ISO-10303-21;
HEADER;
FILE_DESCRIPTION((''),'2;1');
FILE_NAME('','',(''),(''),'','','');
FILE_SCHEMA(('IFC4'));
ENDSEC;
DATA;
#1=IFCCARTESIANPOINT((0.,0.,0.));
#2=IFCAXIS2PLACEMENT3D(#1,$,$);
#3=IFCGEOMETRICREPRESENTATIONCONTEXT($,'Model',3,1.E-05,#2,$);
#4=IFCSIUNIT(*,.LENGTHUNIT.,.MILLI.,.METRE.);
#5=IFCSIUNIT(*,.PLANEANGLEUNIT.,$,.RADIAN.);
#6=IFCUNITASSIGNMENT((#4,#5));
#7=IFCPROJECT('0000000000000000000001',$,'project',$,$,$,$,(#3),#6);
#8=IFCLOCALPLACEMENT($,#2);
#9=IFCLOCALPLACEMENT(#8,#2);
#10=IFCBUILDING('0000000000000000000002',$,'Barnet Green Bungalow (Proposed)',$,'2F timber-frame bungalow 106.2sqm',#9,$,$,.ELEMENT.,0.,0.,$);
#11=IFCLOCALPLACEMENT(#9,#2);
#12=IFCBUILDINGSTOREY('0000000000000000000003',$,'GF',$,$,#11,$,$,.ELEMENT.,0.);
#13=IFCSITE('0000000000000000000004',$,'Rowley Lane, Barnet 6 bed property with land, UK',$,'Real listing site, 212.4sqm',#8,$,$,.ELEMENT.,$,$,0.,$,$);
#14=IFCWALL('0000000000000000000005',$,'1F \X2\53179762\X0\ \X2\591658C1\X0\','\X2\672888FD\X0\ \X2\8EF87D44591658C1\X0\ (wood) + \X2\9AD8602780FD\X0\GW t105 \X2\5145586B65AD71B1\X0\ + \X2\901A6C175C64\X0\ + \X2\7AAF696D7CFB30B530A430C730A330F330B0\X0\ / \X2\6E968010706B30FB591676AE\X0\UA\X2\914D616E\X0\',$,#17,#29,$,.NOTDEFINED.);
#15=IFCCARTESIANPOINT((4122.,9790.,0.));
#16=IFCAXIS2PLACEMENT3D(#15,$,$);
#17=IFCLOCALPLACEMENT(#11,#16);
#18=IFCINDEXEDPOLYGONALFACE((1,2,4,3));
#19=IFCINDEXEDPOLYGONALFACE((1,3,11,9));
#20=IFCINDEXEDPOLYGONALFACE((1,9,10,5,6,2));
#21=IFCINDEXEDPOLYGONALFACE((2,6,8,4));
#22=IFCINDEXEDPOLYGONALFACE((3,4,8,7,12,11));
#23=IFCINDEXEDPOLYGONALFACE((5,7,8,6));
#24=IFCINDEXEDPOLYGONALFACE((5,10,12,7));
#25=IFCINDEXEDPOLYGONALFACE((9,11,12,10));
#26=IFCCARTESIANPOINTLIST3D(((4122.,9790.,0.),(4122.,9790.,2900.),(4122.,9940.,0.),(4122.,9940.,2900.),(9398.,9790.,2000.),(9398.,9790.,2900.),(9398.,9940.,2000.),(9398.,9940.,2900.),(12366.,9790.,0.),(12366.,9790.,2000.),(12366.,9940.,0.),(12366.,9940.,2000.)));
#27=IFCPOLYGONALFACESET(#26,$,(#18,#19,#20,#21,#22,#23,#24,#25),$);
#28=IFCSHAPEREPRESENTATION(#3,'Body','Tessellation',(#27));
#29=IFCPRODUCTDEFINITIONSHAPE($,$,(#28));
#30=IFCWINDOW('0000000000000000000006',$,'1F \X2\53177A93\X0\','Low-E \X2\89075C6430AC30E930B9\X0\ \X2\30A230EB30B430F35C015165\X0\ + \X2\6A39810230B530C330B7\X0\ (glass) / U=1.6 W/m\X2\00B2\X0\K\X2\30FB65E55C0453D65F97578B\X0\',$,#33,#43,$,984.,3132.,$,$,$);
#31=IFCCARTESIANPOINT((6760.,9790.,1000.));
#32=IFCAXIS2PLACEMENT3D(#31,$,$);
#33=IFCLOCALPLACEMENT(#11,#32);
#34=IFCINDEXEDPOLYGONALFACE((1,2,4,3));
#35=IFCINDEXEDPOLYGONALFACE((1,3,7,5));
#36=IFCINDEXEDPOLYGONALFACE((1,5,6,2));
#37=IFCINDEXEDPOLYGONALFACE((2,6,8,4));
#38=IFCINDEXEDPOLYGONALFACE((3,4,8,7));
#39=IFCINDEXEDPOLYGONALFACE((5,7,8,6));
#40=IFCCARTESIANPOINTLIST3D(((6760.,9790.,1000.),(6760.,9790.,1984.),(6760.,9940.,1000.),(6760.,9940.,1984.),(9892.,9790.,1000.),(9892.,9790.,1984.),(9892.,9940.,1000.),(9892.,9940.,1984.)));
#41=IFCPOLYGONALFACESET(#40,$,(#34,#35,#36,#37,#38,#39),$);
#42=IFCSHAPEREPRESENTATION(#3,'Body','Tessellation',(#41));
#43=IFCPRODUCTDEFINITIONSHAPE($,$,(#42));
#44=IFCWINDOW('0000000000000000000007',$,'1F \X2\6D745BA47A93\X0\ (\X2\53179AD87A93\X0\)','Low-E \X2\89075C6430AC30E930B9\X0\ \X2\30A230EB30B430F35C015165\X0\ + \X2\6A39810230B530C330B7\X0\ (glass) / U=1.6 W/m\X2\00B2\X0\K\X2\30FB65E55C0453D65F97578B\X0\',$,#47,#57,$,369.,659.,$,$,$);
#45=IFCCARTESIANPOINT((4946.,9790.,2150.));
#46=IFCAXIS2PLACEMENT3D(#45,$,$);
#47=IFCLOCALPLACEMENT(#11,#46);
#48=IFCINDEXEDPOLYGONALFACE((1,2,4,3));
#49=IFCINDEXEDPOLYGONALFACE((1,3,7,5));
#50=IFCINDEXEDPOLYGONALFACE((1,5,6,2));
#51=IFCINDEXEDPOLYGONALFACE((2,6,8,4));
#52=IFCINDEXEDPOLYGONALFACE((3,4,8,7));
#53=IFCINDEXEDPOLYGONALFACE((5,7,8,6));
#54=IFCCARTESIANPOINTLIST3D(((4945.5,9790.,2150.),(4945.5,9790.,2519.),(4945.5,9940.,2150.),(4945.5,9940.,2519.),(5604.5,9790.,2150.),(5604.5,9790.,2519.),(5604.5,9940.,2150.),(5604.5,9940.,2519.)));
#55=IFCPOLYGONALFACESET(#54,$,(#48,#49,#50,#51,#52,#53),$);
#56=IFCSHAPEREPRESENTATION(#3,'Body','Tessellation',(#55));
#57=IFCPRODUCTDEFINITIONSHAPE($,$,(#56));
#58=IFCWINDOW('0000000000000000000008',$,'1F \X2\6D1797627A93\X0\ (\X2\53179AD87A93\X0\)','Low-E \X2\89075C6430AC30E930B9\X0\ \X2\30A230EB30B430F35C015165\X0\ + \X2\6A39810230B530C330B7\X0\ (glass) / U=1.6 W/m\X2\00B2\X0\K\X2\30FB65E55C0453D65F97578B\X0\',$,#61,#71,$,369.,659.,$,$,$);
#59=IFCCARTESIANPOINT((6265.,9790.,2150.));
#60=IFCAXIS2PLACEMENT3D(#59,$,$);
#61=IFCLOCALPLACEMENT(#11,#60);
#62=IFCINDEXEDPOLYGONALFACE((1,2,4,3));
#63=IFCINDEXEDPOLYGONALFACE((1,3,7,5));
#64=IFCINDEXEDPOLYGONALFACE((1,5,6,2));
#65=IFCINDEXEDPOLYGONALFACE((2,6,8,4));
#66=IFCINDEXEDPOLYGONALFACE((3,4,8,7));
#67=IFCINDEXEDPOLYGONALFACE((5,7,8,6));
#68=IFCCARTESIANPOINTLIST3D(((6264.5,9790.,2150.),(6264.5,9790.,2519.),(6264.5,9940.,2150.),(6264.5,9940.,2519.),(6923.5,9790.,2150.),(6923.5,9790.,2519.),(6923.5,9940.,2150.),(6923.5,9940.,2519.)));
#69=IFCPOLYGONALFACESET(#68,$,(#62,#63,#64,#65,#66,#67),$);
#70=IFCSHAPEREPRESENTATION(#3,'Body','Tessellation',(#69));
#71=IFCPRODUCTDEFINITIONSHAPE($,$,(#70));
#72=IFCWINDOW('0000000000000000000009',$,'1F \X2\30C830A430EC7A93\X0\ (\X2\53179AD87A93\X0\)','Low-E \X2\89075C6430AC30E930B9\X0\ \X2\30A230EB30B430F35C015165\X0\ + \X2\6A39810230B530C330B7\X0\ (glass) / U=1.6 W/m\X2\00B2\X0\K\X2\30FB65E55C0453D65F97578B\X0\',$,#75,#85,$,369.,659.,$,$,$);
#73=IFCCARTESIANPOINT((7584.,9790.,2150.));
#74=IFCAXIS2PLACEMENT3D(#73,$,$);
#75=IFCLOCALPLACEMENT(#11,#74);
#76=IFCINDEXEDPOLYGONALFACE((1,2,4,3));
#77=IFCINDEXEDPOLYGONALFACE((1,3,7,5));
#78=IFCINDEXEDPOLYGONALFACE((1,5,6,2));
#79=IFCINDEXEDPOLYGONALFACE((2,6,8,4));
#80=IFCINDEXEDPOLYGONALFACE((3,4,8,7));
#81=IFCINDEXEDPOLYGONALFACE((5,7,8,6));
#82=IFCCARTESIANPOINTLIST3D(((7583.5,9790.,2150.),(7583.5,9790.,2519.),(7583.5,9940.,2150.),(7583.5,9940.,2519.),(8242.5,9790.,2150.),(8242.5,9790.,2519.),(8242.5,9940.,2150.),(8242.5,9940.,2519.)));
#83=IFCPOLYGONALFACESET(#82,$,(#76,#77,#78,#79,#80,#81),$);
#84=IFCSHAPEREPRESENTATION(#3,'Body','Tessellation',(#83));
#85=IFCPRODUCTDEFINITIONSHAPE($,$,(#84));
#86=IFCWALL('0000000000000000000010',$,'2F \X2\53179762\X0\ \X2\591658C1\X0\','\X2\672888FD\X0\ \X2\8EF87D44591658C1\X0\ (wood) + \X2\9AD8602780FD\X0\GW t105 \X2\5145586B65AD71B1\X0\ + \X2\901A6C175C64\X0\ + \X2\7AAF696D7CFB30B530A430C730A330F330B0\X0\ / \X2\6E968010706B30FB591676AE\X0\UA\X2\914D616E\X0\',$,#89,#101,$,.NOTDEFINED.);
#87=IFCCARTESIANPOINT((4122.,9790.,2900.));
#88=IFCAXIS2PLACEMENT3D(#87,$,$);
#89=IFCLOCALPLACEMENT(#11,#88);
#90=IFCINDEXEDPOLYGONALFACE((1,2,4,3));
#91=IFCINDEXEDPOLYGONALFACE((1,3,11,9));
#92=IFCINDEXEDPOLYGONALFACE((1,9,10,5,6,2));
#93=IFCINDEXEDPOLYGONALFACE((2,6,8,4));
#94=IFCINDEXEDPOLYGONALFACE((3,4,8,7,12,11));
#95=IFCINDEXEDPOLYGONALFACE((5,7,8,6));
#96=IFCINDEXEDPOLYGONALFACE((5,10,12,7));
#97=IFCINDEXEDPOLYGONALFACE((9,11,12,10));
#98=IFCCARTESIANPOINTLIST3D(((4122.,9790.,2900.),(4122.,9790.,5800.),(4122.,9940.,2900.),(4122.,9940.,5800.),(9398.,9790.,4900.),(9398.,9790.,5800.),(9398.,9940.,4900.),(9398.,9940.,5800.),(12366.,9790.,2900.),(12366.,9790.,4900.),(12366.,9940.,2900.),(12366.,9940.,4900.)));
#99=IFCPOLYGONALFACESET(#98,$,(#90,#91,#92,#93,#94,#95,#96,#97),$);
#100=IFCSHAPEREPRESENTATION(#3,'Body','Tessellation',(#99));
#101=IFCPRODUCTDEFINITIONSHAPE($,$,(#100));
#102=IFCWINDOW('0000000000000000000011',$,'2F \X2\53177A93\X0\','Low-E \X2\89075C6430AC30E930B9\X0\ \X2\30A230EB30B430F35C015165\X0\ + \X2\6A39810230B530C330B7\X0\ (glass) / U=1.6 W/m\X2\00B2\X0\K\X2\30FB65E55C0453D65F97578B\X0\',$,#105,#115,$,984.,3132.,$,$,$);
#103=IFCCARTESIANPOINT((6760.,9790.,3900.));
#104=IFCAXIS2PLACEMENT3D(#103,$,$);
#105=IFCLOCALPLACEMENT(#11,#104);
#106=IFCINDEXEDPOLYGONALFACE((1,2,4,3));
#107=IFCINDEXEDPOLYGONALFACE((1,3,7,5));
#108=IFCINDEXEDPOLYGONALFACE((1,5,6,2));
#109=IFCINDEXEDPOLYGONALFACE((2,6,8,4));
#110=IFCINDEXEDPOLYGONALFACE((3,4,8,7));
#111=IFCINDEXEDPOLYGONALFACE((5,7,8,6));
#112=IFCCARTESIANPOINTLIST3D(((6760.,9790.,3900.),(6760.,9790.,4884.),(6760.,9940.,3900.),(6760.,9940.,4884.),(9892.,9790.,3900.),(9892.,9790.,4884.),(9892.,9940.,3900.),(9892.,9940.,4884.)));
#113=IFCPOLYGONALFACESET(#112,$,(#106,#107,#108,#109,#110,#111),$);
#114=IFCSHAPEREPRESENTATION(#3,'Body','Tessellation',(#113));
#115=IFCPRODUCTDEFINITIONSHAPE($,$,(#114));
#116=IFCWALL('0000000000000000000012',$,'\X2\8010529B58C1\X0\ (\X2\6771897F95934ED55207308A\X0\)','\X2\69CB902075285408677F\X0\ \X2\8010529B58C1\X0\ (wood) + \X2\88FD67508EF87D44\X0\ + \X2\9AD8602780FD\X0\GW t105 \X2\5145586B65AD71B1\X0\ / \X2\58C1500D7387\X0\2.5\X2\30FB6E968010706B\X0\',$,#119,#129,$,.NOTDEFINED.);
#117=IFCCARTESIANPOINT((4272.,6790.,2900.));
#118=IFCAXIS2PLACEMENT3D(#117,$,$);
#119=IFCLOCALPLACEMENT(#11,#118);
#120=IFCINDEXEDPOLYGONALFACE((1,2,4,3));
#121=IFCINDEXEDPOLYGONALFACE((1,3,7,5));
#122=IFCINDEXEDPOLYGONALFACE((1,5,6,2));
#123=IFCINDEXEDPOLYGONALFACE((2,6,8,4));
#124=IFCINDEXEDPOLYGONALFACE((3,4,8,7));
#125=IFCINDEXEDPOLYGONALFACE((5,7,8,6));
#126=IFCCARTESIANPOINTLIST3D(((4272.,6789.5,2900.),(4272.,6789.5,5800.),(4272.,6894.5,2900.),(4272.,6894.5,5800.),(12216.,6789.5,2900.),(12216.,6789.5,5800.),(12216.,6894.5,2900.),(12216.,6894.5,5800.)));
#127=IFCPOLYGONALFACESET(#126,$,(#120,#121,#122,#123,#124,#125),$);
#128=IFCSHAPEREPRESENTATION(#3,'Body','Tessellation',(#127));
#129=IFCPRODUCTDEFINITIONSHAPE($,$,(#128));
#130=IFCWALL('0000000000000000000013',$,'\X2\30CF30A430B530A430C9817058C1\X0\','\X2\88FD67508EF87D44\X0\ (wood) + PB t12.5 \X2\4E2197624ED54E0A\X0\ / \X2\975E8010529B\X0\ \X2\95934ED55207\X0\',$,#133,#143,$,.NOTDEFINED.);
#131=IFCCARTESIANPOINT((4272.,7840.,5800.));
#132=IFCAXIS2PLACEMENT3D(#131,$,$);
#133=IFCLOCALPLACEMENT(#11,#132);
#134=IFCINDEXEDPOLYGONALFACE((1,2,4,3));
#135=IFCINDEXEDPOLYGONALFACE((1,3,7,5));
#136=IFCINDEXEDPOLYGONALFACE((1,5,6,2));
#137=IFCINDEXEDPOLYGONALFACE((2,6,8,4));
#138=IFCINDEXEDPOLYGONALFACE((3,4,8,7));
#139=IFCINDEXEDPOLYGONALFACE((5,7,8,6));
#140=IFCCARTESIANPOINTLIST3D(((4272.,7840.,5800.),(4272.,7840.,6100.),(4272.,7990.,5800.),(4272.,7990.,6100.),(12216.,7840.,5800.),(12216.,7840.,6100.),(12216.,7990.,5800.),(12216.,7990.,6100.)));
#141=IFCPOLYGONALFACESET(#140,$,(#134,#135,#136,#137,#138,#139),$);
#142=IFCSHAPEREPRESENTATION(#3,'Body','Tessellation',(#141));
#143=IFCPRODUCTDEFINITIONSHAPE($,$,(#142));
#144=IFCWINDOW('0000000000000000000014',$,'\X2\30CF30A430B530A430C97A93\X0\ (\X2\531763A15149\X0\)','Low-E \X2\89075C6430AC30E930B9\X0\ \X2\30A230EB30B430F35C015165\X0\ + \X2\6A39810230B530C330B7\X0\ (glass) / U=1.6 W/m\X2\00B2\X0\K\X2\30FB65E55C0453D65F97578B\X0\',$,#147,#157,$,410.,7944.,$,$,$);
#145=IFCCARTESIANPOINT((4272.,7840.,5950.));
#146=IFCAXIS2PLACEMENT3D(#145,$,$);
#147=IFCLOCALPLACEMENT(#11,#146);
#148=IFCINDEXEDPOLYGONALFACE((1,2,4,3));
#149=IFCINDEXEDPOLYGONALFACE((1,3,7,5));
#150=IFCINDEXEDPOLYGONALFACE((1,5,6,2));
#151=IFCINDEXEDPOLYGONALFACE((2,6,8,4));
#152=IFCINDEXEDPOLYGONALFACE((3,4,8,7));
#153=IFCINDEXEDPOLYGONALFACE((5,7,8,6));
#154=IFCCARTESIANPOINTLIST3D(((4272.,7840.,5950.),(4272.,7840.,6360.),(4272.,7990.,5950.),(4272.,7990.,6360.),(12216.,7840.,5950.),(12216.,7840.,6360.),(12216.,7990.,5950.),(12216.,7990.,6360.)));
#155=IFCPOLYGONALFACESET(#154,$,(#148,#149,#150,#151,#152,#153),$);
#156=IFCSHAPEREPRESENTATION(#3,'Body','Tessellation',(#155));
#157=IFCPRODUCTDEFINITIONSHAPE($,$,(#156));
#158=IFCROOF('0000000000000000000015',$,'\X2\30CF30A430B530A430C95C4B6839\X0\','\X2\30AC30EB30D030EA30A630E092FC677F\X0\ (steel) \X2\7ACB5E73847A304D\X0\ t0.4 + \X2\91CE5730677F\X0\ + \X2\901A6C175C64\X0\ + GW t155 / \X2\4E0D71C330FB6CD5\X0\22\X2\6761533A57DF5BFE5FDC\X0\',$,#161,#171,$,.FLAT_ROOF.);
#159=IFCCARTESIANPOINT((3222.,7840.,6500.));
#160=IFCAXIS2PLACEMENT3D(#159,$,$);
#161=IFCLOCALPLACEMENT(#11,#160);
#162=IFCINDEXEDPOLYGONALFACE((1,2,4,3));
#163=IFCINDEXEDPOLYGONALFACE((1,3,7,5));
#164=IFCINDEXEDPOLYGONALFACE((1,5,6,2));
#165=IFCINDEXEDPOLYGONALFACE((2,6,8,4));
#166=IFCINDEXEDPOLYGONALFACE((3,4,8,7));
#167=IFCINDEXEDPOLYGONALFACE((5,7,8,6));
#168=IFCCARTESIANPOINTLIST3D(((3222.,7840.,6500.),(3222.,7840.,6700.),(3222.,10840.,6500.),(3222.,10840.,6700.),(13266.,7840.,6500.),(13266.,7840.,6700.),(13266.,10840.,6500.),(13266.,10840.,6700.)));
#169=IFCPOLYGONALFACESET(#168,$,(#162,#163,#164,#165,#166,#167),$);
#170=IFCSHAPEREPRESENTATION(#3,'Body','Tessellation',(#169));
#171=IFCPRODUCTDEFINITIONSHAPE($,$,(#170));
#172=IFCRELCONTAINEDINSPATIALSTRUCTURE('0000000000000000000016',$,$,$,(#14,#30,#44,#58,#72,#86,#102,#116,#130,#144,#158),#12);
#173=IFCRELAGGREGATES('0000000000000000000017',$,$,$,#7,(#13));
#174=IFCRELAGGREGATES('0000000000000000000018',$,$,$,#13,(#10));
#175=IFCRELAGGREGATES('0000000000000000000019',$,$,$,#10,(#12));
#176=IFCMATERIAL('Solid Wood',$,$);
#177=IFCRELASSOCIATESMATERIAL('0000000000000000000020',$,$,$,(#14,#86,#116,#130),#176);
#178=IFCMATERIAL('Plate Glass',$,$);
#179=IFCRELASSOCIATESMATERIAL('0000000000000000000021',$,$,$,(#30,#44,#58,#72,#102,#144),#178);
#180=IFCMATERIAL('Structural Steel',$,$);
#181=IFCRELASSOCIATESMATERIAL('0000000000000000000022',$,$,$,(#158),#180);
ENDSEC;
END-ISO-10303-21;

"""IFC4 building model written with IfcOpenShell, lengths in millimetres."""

from ifc_helpers import new_model, si_unit, frame, frame_2d, origin, place, context, project, spatial, rectangle, extrude, material, element, fill, save


model = new_model("IFC4")

# Units and contexts
model_context = context("Model", 3, precision=1e-05, world=origin())
ifc_project = project(units=[si_unit("LENGTHUNIT", "METRE", prefix="MILLI"), si_unit("PLANEANGLEUNIT", "RADIAN")], contexts=[model_context])

# Site, building, storey
site_placement = place(None, origin())
site = spatial("IfcSite", under=ifc_project, at=site_placement, Name="Rowley Lane, Barnet 6 bed property with land, UK", ObjectType="Real listing site, 212.4sqm", CompositionType="ELEMENT", RefElevation=0.0)
building_placement = place(site_placement, origin())
building = spatial("IfcBuilding", under=site, at=building_placement, Name="Barnet Green Bungalow (Proposed)", ObjectType="2F timber-frame bungalow 106.2sqm", CompositionType="ELEMENT", ElevationOfRefHeight=0.0, ElevationOfTerrain=0.0)
storey_placement = place(building_placement, origin())
storey = spatial("IfcBuildingStorey", under=building, at=storey_placement, Name="GF", CompositionType="ELEMENT", Elevation=0.0)

# Wall, openings, windows
ifc_material_1 = material(Name="Solid Wood")
wall_1_placement = place(storey_placement, frame((4122.0, 9790.0, 0.0)))
wall_1 = element("IfcWall", 1, at=wall_1_placement, inside=storey, material=ifc_material_1, Name="1F 北面 外壁", Description="木製 軸組外壁 (wood) + 高性能GW t105 充填断熱 + 通気層 + 窯業系サイディング / 準耐火・外皮UA配慮", PredefinedType="NOTDEFINED", context=model_context, shape_type="SweptSolid", body=[
    extrude(rectangle(XDim=8244.0, YDim=150.0, at=frame_2d((4122.0, 75.0))), frame((4122.0, 9790.0, 0.0)), (0.0, 0.0, 1.0), 2900.0),
])
opening_1_placement = place(storey_placement, frame((6760.0, 9790.0, 1000.0)))
opening_1 = element("IfcOpeningElement", 2, at=opening_1_placement, cuts=wall_1, PredefinedType="NOTDEFINED", context=model_context, shape_type="SweptSolid", body=[
    extrude(rectangle(XDim=3132.0, YDim=150.0, at=frame_2d((1566.0, 75.0))), frame((6760.0, 9790.0, 1000.0)), (0.0, 0.0, 1.0), 984.0),
])
opening_2_placement = place(storey_placement, frame((4946.0, 9790.0, 2150.0)))
opening_2 = element("IfcOpeningElement", 3, at=opening_2_placement, cuts=wall_1, PredefinedType="NOTDEFINED", context=model_context, shape_type="SweptSolid", body=[
    extrude(rectangle(XDim=659.0, YDim=150.0, at=frame_2d((329.0, 75.0))), frame((4946.0, 9790.0, 2150.0)), (0.0, 0.0, 1.0), 369.0),
])
opening_3_placement = place(storey_placement, frame((6265.0, 9790.0, 2150.0)))
opening_3 = element("IfcOpeningElement", 4, at=opening_3_placement, cuts=wall_1, PredefinedType="NOTDEFINED", context=model_context, shape_type="SweptSolid", body=[
    extrude(rectangle(XDim=659.0, YDim=150.0, at=frame_2d((329.0, 75.0))), frame((6265.0, 9790.0, 2150.0)), (0.0, 0.0, 1.0), 369.0),
])
opening_4_placement = place(storey_placement, frame((7584.0, 9790.0, 2150.0)))
opening_4 = element("IfcOpeningElement", 5, at=opening_4_placement, cuts=wall_1, PredefinedType="NOTDEFINED", context=model_context, shape_type="SweptSolid", body=[
    extrude(rectangle(XDim=659.0, YDim=150.0, at=frame_2d((329.0, 75.0))), frame((7584.0, 9790.0, 2150.0)), (0.0, 0.0, 1.0), 369.0),
])
ifc_material_2 = material(Name="Plate Glass")
window_1_placement = place(storey_placement, frame((6760.0, 9790.0, 1000.0)))
window_1 = element("IfcWindow", 6, at=window_1_placement, inside=storey, material=ifc_material_2, Name="1F 北窓", Description="Low-E 複層ガラス アルゴン封入 + 樹脂サッシ (glass) / U=1.6 W/m²K・日射取得型", OverallHeight=984.0, OverallWidth=3132.0, context=model_context, shape_type="SweptSolid", body=[
    extrude(rectangle(XDim=3132.0, YDim=150.0, at=frame_2d((1566.0, 75.0))), frame((6760.0, 9790.0, 1000.0)), (0.0, 0.0, 1.0), 984.0),
])
fill(opening_1, window_1)
window_2_placement = place(storey_placement, frame((4946.0, 9790.0, 2150.0)))
window_2 = element("IfcWindow", 7, at=window_2_placement, inside=storey, material=ifc_material_2, Name="1F 浴室窓 (北高窓)", Description="Low-E 複層ガラス アルゴン封入 + 樹脂サッシ (glass) / U=1.6 W/m²K・日射取得型", OverallHeight=369.0, OverallWidth=659.0, context=model_context, shape_type="SweptSolid", body=[
    extrude(rectangle(XDim=659.0, YDim=150.0, at=frame_2d((329.0, 75.0))), frame((4946.0, 9790.0, 2150.0)), (0.0, 0.0, 1.0), 369.0),
])
fill(opening_2, window_2)
window_3_placement = place(storey_placement, frame((6265.0, 9790.0, 2150.0)))
window_3 = element("IfcWindow", 8, at=window_3_placement, inside=storey, material=ifc_material_2, Name="1F 洗面窓 (北高窓)", Description="Low-E 複層ガラス アルゴン封入 + 樹脂サッシ (glass) / U=1.6 W/m²K・日射取得型", OverallHeight=369.0, OverallWidth=659.0, context=model_context, shape_type="SweptSolid", body=[
    extrude(rectangle(XDim=659.0, YDim=150.0, at=frame_2d((329.0, 75.0))), frame((6265.0, 9790.0, 2150.0)), (0.0, 0.0, 1.0), 369.0),
])
fill(opening_3, window_3)
window_4_placement = place(storey_placement, frame((7584.0, 9790.0, 2150.0)))
window_4 = element("IfcWindow", 9, at=window_4_placement, inside=storey, material=ifc_material_2, Name="1F トイレ窓 (北高窓)", Description="Low-E 複層ガラス アルゴン封入 + 樹脂サッシ (glass) / U=1.6 W/m²K・日射取得型", OverallHeight=369.0, OverallWidth=659.0, context=model_context, shape_type="SweptSolid", body=[
    extrude(rectangle(XDim=659.0, YDim=150.0, at=frame_2d((329.0, 75.0))), frame((7584.0, 9790.0, 2150.0)), (0.0, 0.0, 1.0), 369.0),
])
fill(opening_4, window_4)

# Wall, opening, window
wall_2_placement = place(storey_placement, frame((4122.0, 9790.0, 2900.0)))
wall_2 = element("IfcWall", 10, at=wall_2_placement, inside=storey, material=ifc_material_1, Name="2F 北面 外壁", Description="木製 軸組外壁 (wood) + 高性能GW t105 充填断熱 + 通気層 + 窯業系サイディング / 準耐火・外皮UA配慮", PredefinedType="NOTDEFINED", context=model_context, shape_type="SweptSolid", body=[
    extrude(rectangle(XDim=8244.0, YDim=150.0, at=frame_2d((4122.0, 75.0))), frame((4122.0, 9790.0, 2900.0)), (0.0, 0.0, 1.0), 2900.0),
])
opening_5_placement = place(storey_placement, frame((6760.0, 9790.0, 3900.0)))
opening_5 = element("IfcOpeningElement", 11, at=opening_5_placement, cuts=wall_2, PredefinedType="NOTDEFINED", context=model_context, shape_type="SweptSolid", body=[
    extrude(rectangle(XDim=3132.0, YDim=150.0, at=frame_2d((1566.0, 75.0))), frame((6760.0, 9790.0, 3900.0)), (0.0, 0.0, 1.0), 984.0),
])
window_5_placement = place(storey_placement, frame((6760.0, 9790.0, 3900.0)))
window_5 = element("IfcWindow", 12, at=window_5_placement, inside=storey, material=ifc_material_2, Name="2F 北窓", Description="Low-E 複層ガラス アルゴン封入 + 樹脂サッシ (glass) / U=1.6 W/m²K・日射取得型", OverallHeight=984.0, OverallWidth=3132.0, context=model_context, shape_type="SweptSolid", body=[
    extrude(rectangle(XDim=3132.0, YDim=150.0, at=frame_2d((1566.0, 75.0))), frame((6760.0, 9790.0, 3900.0)), (0.0, 0.0, 1.0), 984.0),
])
fill(opening_5, window_5)

# Wall
wall_3_placement = place(storey_placement, frame((4272.0, 6790.0, 2900.0)))
element("IfcWall", 13, at=wall_3_placement, inside=storey, material=ifc_material_1, Name="耐力壁 (東西間仕切り)", Description="構造用合板 耐力壁 (wood) + 製材軸組 + 高性能GW t105 充填断熱 / 壁倍率2.5・準耐火", PredefinedType="NOTDEFINED", context=model_context, shape_type="SweptSolid", body=[
    extrude(rectangle(XDim=7944.0, YDim=105.0, at=frame_2d((3972.0, 52.0))), frame((4272.0, 6790.0, 2900.0)), (0.0, 0.0, 1.0), 2900.0),
])

# Wall, opening, window
wall_4_placement = place(storey_placement, frame((4272.0, 7840.0, 5800.0)))
wall_4 = element("IfcWall", 14, at=wall_4_placement, inside=storey, material=ifc_material_1, Name="ハイサイド腰壁", Description="製材軸組 (wood) + PB t12.5 両面仕上 / 非耐力 間仕切", PredefinedType="NOTDEFINED", context=model_context, shape_type="SweptSolid", body=[
    extrude(rectangle(XDim=7944.0, YDim=150.0, at=frame_2d((3972.0, 75.0))), frame((4272.0, 7840.0, 5800.0)), (0.0, 0.0, 1.0), 700.0),
])
opening_6_placement = place(storey_placement, frame((4272.0, 7840.0, 5950.0)))
opening_6 = element("IfcOpeningElement", 15, at=opening_6_placement, cuts=wall_4, PredefinedType="NOTDEFINED", context=model_context, shape_type="SweptSolid", body=[
    extrude(rectangle(XDim=7944.0, YDim=150.0, at=frame_2d((3972.0, 75.0))), frame((4272.0, 7840.0, 5950.0)), (0.0, 0.0, 1.0), 410.0),
])
window_6_placement = place(storey_placement, frame((4272.0, 7840.0, 5950.0)))
window_6 = element("IfcWindow", 16, at=window_6_placement, inside=storey, material=ifc_material_2, Name="ハイサイド窓 (北採光)", Description="Low-E 複層ガラス アルゴン封入 + 樹脂サッシ (glass) / U=1.6 W/m²K・日射取得型", OverallHeight=410.0, OverallWidth=7944.0, context=model_context, shape_type="SweptSolid", body=[
    extrude(rectangle(XDim=7944.0, YDim=150.0, at=frame_2d((3972.0, 75.0))), frame((4272.0, 7840.0, 5950.0)), (0.0, 0.0, 1.0), 410.0),
])
fill(opening_6, window_6)

# Roof
ifc_material_3 = material(Name="Structural Steel")
roof_placement = place(storey_placement, frame((3222.0, 7840.0, 6500.0)))
element("IfcRoof", 17, at=roof_placement, inside=storey, material=ifc_material_3, Name="ハイサイド屋根", Description="ガルバリウム鋼板 (steel) 立平葺き t0.4 + 野地板 + 通気層 + GW t155 / 不燃・法22条区域対応", PredefinedType="FLAT_ROOF", context=model_context, shape_type="SweptSolid", body=[
    extrude(rectangle(XDim=10044.0, YDim=3000.0, at=frame_2d((5022.0, 1500.0))), frame((3222.0, 7840.0, 6500.0)), (0.0, 0.0, 1.0), 200.0),
])

save(model, "model.ifc")
